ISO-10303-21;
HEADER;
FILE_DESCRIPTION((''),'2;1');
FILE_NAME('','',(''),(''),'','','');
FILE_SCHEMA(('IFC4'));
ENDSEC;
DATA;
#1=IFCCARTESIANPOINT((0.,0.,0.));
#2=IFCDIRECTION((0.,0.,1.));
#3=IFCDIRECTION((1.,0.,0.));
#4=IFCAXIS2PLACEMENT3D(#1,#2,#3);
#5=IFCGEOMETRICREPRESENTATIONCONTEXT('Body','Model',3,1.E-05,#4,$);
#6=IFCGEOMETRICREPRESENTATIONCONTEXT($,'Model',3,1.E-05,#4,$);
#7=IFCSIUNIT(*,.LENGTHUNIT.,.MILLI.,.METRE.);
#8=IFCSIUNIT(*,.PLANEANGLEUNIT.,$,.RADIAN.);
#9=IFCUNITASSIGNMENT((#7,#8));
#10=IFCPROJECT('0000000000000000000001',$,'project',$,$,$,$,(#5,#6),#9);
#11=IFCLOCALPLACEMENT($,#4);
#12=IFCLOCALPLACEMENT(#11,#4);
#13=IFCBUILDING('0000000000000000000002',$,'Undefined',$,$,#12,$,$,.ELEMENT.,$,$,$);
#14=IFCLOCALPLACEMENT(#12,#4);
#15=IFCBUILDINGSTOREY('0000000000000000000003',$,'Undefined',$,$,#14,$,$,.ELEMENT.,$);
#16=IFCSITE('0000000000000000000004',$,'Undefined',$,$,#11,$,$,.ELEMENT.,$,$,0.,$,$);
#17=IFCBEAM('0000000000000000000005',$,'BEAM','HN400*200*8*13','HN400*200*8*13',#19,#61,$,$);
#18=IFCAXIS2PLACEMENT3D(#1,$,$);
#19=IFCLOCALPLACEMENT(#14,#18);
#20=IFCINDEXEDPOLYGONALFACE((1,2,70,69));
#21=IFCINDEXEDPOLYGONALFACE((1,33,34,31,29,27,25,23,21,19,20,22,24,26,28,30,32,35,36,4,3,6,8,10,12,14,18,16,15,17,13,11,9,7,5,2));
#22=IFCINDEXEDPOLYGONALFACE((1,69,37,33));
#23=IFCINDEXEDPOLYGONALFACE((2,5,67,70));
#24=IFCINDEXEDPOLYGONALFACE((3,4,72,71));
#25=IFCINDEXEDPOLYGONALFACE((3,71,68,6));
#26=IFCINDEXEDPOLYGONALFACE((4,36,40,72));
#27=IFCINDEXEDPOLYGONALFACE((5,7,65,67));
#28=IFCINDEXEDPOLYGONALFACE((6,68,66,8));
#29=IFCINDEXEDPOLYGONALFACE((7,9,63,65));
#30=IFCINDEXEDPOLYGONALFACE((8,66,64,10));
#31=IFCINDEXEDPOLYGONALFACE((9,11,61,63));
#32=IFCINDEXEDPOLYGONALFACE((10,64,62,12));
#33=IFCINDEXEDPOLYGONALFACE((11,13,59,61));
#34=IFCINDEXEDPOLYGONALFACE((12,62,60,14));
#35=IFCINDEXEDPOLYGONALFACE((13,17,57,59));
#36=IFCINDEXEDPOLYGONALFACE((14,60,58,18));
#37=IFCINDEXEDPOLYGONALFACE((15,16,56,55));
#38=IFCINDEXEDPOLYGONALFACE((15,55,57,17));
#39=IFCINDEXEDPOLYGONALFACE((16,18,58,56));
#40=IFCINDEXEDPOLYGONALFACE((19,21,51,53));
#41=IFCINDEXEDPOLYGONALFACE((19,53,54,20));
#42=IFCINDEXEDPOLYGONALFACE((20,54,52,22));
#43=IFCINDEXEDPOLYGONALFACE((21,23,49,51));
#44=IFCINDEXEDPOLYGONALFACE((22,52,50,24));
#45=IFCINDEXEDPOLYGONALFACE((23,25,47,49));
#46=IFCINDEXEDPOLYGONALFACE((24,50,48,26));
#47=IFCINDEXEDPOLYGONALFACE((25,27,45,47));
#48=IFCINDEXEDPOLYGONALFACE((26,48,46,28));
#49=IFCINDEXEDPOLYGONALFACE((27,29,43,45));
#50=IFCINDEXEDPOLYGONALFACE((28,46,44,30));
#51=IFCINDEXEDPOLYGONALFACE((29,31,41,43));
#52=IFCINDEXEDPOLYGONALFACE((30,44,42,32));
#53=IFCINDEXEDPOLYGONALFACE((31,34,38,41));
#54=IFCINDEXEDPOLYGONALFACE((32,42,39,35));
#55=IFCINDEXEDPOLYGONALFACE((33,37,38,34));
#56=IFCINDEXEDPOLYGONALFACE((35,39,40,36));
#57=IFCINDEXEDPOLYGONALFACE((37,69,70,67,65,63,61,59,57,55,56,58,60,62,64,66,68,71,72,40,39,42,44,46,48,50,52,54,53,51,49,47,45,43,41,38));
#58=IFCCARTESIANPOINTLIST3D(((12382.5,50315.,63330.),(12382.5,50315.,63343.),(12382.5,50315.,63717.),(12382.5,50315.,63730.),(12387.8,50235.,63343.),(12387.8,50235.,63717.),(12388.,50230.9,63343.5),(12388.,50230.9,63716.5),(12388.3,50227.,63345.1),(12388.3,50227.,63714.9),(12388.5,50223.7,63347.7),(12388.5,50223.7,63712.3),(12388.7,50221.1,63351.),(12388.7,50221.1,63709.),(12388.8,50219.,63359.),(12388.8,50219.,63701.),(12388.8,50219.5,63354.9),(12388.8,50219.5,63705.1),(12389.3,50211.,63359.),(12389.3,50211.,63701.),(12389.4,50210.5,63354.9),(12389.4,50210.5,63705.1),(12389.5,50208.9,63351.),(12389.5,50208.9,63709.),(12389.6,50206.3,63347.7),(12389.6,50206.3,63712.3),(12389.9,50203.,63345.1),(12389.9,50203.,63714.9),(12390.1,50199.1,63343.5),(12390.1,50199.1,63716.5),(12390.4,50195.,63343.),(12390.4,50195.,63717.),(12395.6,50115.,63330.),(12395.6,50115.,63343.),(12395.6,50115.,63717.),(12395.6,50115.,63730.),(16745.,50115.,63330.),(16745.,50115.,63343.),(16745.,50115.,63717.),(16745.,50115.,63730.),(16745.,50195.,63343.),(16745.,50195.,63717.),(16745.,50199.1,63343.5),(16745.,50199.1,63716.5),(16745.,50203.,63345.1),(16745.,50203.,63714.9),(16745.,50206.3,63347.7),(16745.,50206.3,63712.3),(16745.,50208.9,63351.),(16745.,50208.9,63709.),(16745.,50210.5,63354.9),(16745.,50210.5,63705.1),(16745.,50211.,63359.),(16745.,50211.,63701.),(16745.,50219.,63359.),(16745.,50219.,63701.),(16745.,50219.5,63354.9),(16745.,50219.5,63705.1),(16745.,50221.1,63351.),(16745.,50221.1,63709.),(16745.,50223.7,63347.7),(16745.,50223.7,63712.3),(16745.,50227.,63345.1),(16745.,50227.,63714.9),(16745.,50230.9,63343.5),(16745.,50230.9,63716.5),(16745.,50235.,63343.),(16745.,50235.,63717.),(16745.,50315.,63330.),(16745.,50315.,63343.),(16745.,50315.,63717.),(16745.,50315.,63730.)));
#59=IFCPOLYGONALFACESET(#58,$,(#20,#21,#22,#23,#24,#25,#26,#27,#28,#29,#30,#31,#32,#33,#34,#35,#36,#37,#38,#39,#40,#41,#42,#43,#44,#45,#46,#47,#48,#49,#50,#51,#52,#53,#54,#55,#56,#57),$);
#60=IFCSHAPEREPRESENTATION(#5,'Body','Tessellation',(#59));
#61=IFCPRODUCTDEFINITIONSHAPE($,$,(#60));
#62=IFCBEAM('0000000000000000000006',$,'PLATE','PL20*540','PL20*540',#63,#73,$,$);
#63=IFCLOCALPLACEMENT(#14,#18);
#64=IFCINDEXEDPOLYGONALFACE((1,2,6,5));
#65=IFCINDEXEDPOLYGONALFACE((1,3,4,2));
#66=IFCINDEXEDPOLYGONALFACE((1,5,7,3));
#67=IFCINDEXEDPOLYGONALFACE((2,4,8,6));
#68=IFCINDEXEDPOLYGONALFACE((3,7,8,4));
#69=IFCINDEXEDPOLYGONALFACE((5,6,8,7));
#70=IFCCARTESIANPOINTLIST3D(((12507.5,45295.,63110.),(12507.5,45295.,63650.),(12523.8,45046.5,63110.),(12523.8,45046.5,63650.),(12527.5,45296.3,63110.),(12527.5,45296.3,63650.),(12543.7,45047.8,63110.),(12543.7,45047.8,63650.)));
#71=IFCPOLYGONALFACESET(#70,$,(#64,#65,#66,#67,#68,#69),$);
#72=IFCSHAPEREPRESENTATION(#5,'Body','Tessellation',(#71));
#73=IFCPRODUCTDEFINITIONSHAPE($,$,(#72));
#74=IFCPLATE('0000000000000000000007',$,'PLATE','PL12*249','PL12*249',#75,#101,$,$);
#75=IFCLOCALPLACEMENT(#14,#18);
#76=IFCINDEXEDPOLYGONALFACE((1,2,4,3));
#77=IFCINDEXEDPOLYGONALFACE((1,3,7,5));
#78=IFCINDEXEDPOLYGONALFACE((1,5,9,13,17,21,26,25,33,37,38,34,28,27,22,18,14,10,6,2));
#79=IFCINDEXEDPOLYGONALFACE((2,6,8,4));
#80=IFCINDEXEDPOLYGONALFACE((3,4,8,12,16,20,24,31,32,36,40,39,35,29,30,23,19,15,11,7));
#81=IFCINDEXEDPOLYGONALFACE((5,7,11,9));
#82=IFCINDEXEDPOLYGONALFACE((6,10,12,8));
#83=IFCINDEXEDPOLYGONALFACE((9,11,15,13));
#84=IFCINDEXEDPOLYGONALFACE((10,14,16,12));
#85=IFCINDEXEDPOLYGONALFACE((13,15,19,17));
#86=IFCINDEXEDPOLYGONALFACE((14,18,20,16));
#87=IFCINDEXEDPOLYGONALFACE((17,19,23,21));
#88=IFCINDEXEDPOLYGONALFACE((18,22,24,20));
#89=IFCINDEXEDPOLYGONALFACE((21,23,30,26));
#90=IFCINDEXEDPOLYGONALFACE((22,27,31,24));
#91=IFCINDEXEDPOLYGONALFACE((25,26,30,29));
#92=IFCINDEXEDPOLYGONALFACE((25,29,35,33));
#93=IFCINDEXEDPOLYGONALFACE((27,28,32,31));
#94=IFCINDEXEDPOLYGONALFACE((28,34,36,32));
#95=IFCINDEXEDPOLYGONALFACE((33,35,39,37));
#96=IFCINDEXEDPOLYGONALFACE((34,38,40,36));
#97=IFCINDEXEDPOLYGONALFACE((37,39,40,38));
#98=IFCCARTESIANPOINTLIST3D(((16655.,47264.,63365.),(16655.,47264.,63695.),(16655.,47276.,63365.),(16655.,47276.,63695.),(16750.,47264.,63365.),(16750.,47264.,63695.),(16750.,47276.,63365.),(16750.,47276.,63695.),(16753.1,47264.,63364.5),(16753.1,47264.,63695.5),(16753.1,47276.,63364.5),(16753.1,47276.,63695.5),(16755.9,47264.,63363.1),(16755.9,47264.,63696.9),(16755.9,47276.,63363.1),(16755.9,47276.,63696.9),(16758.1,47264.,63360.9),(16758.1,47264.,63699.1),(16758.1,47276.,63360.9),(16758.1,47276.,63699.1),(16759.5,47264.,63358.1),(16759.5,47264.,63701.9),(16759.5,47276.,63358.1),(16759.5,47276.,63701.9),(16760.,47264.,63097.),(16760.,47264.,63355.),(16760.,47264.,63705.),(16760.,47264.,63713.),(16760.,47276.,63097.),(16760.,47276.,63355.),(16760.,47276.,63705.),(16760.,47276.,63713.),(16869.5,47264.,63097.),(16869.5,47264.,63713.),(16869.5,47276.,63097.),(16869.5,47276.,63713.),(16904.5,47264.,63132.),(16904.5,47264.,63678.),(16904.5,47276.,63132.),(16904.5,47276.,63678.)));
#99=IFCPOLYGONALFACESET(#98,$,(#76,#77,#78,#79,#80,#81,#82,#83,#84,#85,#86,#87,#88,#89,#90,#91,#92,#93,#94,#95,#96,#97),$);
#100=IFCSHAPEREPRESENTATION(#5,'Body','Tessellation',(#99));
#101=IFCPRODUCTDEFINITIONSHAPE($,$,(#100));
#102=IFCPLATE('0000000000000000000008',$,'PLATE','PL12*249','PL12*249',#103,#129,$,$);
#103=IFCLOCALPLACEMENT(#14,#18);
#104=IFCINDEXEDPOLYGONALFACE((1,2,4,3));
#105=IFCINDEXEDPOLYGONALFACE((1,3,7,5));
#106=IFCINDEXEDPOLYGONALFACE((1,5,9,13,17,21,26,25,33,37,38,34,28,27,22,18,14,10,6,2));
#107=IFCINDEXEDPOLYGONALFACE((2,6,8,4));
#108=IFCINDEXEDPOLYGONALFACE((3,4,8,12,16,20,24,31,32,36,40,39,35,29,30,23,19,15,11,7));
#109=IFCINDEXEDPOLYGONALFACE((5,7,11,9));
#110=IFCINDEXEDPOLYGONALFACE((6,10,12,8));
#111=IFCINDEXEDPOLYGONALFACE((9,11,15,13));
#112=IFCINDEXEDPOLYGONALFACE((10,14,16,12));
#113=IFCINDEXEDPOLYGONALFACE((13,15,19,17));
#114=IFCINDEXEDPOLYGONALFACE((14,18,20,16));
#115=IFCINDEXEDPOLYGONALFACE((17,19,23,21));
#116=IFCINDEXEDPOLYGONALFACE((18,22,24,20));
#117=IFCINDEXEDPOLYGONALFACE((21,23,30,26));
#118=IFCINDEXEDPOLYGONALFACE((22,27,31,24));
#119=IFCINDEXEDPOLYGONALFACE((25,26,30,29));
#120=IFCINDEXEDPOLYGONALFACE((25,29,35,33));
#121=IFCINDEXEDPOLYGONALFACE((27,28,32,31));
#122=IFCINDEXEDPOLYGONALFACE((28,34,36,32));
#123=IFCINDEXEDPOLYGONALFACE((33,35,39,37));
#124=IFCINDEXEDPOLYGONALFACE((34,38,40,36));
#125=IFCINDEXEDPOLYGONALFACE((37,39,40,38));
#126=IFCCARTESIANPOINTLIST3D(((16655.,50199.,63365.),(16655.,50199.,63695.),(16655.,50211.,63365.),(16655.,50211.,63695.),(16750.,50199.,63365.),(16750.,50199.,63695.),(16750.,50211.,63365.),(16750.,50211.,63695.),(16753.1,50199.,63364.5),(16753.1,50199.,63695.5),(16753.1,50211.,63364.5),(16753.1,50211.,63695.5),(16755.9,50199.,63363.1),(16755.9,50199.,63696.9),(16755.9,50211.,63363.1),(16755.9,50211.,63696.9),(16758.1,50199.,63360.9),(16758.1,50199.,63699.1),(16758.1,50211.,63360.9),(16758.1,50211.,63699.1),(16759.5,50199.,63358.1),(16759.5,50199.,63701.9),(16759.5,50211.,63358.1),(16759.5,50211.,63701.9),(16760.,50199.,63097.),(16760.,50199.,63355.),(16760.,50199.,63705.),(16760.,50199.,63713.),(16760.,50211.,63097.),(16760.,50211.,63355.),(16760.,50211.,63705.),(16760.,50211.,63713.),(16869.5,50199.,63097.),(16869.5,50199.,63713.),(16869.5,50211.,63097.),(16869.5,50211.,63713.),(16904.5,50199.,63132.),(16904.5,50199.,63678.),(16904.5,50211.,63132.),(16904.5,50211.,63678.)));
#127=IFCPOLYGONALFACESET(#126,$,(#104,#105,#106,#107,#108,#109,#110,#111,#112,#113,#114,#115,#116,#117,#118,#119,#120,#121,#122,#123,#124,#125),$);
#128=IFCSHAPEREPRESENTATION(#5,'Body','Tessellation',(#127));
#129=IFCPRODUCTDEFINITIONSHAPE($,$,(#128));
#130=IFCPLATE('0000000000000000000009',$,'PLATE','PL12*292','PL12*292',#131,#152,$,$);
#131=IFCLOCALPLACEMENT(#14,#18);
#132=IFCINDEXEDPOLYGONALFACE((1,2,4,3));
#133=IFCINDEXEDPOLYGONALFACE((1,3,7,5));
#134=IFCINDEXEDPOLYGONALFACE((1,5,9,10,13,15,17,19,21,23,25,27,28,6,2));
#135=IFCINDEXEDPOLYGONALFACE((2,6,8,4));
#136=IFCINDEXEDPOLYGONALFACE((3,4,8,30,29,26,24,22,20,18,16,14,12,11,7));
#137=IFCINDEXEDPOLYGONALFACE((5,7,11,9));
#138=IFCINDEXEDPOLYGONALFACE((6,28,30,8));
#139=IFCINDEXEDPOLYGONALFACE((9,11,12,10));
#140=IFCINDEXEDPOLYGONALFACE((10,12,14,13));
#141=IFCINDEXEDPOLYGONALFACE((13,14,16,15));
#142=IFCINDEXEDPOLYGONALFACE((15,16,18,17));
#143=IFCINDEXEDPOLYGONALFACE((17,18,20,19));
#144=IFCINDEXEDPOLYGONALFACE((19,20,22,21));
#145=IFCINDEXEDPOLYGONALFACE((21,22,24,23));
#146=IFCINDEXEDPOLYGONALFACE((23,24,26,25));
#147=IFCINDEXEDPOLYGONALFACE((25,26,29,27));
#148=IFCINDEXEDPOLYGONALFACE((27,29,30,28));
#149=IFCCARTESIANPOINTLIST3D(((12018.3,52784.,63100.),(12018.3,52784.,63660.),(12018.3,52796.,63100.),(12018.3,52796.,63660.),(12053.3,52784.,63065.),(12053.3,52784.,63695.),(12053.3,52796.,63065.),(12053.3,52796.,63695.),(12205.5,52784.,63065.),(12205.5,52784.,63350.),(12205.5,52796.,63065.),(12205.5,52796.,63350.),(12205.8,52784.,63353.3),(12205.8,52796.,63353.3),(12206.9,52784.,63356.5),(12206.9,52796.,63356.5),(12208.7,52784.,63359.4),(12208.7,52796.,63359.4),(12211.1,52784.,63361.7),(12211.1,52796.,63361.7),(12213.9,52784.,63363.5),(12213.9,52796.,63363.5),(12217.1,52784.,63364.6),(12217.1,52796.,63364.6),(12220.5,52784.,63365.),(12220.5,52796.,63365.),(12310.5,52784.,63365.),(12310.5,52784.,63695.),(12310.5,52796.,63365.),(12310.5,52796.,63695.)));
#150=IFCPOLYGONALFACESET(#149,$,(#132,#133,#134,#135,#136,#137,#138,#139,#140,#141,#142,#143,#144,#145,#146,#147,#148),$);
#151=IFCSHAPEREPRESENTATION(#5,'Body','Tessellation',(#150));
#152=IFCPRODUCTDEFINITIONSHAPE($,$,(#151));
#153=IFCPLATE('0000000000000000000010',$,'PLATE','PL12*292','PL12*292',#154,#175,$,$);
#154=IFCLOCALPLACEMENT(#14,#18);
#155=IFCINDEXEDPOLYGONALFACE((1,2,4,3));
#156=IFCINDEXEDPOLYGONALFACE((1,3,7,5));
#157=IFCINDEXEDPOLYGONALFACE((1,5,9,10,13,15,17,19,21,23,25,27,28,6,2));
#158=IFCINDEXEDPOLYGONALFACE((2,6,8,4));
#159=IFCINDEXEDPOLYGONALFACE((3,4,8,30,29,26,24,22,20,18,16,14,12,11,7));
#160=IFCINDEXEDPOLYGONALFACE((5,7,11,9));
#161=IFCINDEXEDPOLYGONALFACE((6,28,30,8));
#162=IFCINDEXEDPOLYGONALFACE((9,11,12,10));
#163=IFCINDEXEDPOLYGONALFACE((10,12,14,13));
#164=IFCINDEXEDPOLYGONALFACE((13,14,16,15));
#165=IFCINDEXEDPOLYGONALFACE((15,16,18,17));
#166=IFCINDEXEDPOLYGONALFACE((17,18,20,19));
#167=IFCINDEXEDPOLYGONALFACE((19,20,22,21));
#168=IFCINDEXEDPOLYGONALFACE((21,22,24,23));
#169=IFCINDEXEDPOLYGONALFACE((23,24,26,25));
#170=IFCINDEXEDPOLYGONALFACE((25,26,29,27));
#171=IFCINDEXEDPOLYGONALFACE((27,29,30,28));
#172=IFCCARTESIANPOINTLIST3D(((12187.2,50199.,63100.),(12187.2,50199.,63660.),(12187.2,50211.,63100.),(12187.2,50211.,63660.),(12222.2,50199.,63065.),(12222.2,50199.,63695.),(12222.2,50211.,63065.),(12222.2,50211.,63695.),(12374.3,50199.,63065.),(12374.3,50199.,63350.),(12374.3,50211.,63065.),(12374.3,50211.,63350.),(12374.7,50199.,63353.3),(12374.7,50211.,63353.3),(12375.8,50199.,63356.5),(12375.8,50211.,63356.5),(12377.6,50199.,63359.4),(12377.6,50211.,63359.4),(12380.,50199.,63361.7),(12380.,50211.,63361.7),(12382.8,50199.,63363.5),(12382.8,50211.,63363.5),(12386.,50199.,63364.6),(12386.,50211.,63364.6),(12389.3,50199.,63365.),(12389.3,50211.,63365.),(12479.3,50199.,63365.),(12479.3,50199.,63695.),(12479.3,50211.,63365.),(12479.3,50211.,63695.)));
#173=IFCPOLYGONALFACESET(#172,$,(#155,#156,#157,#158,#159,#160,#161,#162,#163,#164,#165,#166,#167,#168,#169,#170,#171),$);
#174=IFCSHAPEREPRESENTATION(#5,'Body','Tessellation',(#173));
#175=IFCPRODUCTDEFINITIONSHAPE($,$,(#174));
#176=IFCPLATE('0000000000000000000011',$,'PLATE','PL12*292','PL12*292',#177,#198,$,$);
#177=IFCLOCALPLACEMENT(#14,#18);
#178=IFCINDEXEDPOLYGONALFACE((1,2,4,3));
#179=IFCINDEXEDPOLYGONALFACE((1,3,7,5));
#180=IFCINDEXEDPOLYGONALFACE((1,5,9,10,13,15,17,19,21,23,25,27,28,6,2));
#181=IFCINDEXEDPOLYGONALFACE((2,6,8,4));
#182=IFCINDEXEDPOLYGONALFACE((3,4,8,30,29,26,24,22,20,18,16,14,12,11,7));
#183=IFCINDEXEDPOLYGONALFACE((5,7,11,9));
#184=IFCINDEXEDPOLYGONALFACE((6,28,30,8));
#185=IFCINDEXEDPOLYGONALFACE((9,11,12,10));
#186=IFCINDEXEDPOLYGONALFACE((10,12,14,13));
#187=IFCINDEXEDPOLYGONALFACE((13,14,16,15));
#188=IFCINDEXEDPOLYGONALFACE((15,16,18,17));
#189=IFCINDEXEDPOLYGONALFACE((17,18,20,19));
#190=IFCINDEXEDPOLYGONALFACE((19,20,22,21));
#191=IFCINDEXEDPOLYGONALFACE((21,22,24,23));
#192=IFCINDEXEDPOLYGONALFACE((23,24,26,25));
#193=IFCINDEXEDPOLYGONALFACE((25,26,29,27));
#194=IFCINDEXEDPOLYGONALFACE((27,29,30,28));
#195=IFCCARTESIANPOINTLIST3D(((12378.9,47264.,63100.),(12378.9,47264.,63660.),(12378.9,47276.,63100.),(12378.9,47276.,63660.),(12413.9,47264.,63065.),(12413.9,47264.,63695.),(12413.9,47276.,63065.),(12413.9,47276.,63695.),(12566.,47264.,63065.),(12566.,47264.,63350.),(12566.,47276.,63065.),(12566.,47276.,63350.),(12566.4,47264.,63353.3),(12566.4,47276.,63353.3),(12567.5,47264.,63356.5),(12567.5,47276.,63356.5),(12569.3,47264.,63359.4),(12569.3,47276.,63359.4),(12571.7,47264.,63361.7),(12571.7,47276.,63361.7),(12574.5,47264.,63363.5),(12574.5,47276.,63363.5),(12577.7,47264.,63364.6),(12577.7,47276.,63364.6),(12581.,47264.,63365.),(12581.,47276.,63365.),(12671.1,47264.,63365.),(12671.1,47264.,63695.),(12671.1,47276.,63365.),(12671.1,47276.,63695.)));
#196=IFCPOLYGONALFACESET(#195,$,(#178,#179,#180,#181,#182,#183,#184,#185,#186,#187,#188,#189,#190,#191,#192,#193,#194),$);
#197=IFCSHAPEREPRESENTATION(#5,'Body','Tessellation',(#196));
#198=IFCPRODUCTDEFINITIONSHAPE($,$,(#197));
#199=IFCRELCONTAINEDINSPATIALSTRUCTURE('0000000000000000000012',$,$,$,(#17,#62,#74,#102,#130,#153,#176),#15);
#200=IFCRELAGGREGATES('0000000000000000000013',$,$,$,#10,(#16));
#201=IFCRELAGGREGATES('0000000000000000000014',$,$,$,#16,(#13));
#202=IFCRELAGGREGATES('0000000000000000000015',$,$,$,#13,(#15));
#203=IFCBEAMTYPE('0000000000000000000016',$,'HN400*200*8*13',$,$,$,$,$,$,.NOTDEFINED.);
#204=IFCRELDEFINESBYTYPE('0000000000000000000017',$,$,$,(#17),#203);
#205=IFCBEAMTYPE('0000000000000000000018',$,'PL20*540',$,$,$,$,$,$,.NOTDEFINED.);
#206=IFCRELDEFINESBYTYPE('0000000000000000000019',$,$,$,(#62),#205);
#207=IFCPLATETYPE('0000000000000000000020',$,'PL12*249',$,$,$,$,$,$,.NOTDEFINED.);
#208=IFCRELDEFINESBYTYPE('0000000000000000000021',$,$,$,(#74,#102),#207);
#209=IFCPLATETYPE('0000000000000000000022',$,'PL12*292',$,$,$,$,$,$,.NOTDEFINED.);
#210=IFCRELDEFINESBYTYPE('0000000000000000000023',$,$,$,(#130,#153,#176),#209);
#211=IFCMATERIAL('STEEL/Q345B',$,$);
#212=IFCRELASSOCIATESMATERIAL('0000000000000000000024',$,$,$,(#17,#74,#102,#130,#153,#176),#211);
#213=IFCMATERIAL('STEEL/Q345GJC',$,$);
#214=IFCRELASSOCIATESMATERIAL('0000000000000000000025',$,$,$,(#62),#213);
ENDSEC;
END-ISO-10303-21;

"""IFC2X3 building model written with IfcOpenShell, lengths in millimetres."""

from ifc_helpers import new_model, si_unit, frame, origin_with_axes, origin_2d_with_axis, place, context, project, spatial, polyline, rectangle, i_section, outline, extrude, clip, halfspace, material, type_object, element, save


model = new_model("IFC2X3")

# Units and contexts
model_context_1 = context("Model", 3, precision=1e-05, world=origin_with_axes(), identifier="Body")
model_context_2 = context("Model", 3, precision=1e-05, world=origin_with_axes())
ifc_project = project(units=[si_unit("LENGTHUNIT", "METRE", prefix="MILLI"), si_unit("PLANEANGLEUNIT", "RADIAN")], contexts=[model_context_1, model_context_2])

# Site, building, storey
site_placement = place(None, origin_with_axes())
site = spatial("IfcSite", under=ifc_project, at=site_placement, Name="Undefined", CompositionType="ELEMENT", RefElevation=0.0)
building_placement = place(site_placement, origin_with_axes())
building = spatial("IfcBuilding", under=site, at=building_placement, Name="Undefined", CompositionType="ELEMENT")
storey_placement = place(building_placement, origin_with_axes())
storey = spatial("IfcBuildingStorey", under=building, at=storey_placement, Name="Undefined", CompositionType="ELEMENT")

# Beams
ifc_material_1 = material(Name="STEEL/Q345B")
beam_type_1 = type_object("IfcBeamType", Name="HN400*200*8*13", PredefinedType="NOTDEFINED")
beam_1_placement = place(storey_placement, frame((12233.9, 50215.0, 63530.0), z_axis=(0.0, 0.0, 1.0), x_axis=(1.0, 0.0, 0.0)))
element("IfcBeam", 1, at=beam_1_placement, inside=storey, type_object=beam_type_1, material=ifc_material_1, Name="BEAM", Description="HN400*200*8*13", ObjectType="HN400*200*8*13", context=model_context_1, shape_type="Clipping", body=[
    clip(clip(extrude(i_section(OverallWidth=200.0, OverallDepth=400.0, WebThickness=8.0, FlangeThickness=13.0, FilletRadius=16.0, at=origin_2d_with_axis()), frame((4511.1, 0.0, 0.0), z_axis=(-1.0, 0.0, 0.0), x_axis=(0.0, -1.0, 0.0)), (0.0, 0.0, 1.0), 4362.5), halfspace(frame((154.3, 13.2, 300.0), z_axis=(-0.997873, -0.065183, 0.0), x_axis=(0.0, 0.0, -1.0)), False)), halfspace(frame((4511.1, 0.0, 300.0), z_axis=(1.0, 0.0, 0.0), x_axis=(0.0, 1.0, 0.0)), False)),
])
ifc_material_2 = material(Name="STEEL/Q345GJC")
beam_type_2 = type_object("IfcBeamType", Name="PL20*540", PredefinedType="NOTDEFINED")
beam_2_placement = place(storey_placement, frame((12533.7, 45047.2, 63380.0), z_axis=(0.0, 0.0, 1.0), x_axis=(-0.065184, 0.997873, 0.0)))
element("IfcBeam", 2, at=beam_2_placement, inside=storey, type_object=beam_type_2, material=ifc_material_2, Name="PLATE", Description="PL20*540", ObjectType="PL20*540", context=model_context_1, shape_type="SweptSolid", body=[
    extrude(rectangle(XDim=20.0, YDim=540.0, at=origin_2d_with_axis()), frame((249.0, 0.0, 0.0), z_axis=(-1.0, 0.0, 0.0), x_axis=(0.0, -1.0, 0.0)), (0.0, 0.0, 1.0), 249.0),
])

# Plates
plate_type_1 = type_object("IfcPlateType", Name="PL12*249", PredefinedType="NOTDEFINED")
for number, where, z_axis, x_axis, name in (
    (3, (16904.5, 47270.0, 63132.0), (0.0, 1.0, 0.0), (-0.707107, 0.0, -0.707107), "PLATE"),
    (4, (16904.5, 50205.0, 63132.0), (0.0, 1.0, 0.0), (-0.707107, 0.0, -0.707107), "PLATE"),
):
    element("IfcPlate", number, at=place(storey_placement, frame(where, z_axis=z_axis, x_axis=x_axis)), inside=storey, type_object=plate_type_1, material=ifc_material_1, Name=name, Description="PL12*249", ObjectType="PL12*249", context=model_context_1, shape_type="SweptSolid", body=[
        extrude(outline(polyline([(0.0, 0.0), (49.5, 0.0), (126.9, 77.4), (-55.5, 259.9), (-57.3, 262.4), (-58.3, 265.4), (-58.3, 268.5), (-57.3, 271.5), (-55.5, 274.0), (11.7, 341.2), (-221.7, 574.5), (-288.9, 507.3), (-291.4, 505.5), (-294.4, 504.5), (-297.5, 504.5), (-300.5, 505.5), (-303.0, 507.3), (-308.7, 513.0), (-386.1, 435.6), (-386.1, 386.1), (0.0, 0.0)])), frame((0.0, 0.0, -6.0), z_axis=(0.0, 0.0, 1.0), x_axis=(1.0, 0.0, 0.0)), (0.0, 0.0, 1.0), 12.0),
    ])
plate_type_2 = type_object("IfcPlateType", Name="PL12*292", PredefinedType="NOTDEFINED")
for number, where, z_axis, x_axis, name in (
    (5, (12310.5, 52790.0, 63695.0), (0.0, 1.0, 0.0), (0.0, 0.0, -1.0), "PLATE"),
    (6, (12479.3, 50205.0, 63695.0), (0.0, 1.0, 0.0), (0.0, 0.0, -1.0), "PLATE"),
    (7, (12671.1, 47270.0, 63695.0), (0.0, 1.0, 0.0), (0.0, 0.0, -1.0), "PLATE"),
):
    element("IfcPlate", number, at=place(storey_placement, frame(where, z_axis=z_axis, x_axis=x_axis)), inside=storey, type_object=plate_type_2, material=ifc_material_1, Name=name, Description="PL12*292", ObjectType="PL12*292", context=model_context_1, shape_type="SweptSolid", body=[
        extrude(outline(polyline([(0.0, 0.0), (330.0, 0.0), (330.0, 90.0), (330.4, 93.4), (331.5, 96.5), (333.3, 99.4), (335.6, 101.8), (338.5, 103.5), (341.7, 104.7), (345.0, 105.0), (630.0, 105.0), (630.0, 257.1), (595.0, 292.1), (35.0, 292.1), (0.0, 257.1), (0.0, 0.0)])), frame((0.0, 0.0, -6.0), z_axis=(0.0, 0.0, 1.0), x_axis=(1.0, 0.0, 0.0)), (0.0, 0.0, 1.0), 12.0),
    ])

save(model, "model.ifc")
